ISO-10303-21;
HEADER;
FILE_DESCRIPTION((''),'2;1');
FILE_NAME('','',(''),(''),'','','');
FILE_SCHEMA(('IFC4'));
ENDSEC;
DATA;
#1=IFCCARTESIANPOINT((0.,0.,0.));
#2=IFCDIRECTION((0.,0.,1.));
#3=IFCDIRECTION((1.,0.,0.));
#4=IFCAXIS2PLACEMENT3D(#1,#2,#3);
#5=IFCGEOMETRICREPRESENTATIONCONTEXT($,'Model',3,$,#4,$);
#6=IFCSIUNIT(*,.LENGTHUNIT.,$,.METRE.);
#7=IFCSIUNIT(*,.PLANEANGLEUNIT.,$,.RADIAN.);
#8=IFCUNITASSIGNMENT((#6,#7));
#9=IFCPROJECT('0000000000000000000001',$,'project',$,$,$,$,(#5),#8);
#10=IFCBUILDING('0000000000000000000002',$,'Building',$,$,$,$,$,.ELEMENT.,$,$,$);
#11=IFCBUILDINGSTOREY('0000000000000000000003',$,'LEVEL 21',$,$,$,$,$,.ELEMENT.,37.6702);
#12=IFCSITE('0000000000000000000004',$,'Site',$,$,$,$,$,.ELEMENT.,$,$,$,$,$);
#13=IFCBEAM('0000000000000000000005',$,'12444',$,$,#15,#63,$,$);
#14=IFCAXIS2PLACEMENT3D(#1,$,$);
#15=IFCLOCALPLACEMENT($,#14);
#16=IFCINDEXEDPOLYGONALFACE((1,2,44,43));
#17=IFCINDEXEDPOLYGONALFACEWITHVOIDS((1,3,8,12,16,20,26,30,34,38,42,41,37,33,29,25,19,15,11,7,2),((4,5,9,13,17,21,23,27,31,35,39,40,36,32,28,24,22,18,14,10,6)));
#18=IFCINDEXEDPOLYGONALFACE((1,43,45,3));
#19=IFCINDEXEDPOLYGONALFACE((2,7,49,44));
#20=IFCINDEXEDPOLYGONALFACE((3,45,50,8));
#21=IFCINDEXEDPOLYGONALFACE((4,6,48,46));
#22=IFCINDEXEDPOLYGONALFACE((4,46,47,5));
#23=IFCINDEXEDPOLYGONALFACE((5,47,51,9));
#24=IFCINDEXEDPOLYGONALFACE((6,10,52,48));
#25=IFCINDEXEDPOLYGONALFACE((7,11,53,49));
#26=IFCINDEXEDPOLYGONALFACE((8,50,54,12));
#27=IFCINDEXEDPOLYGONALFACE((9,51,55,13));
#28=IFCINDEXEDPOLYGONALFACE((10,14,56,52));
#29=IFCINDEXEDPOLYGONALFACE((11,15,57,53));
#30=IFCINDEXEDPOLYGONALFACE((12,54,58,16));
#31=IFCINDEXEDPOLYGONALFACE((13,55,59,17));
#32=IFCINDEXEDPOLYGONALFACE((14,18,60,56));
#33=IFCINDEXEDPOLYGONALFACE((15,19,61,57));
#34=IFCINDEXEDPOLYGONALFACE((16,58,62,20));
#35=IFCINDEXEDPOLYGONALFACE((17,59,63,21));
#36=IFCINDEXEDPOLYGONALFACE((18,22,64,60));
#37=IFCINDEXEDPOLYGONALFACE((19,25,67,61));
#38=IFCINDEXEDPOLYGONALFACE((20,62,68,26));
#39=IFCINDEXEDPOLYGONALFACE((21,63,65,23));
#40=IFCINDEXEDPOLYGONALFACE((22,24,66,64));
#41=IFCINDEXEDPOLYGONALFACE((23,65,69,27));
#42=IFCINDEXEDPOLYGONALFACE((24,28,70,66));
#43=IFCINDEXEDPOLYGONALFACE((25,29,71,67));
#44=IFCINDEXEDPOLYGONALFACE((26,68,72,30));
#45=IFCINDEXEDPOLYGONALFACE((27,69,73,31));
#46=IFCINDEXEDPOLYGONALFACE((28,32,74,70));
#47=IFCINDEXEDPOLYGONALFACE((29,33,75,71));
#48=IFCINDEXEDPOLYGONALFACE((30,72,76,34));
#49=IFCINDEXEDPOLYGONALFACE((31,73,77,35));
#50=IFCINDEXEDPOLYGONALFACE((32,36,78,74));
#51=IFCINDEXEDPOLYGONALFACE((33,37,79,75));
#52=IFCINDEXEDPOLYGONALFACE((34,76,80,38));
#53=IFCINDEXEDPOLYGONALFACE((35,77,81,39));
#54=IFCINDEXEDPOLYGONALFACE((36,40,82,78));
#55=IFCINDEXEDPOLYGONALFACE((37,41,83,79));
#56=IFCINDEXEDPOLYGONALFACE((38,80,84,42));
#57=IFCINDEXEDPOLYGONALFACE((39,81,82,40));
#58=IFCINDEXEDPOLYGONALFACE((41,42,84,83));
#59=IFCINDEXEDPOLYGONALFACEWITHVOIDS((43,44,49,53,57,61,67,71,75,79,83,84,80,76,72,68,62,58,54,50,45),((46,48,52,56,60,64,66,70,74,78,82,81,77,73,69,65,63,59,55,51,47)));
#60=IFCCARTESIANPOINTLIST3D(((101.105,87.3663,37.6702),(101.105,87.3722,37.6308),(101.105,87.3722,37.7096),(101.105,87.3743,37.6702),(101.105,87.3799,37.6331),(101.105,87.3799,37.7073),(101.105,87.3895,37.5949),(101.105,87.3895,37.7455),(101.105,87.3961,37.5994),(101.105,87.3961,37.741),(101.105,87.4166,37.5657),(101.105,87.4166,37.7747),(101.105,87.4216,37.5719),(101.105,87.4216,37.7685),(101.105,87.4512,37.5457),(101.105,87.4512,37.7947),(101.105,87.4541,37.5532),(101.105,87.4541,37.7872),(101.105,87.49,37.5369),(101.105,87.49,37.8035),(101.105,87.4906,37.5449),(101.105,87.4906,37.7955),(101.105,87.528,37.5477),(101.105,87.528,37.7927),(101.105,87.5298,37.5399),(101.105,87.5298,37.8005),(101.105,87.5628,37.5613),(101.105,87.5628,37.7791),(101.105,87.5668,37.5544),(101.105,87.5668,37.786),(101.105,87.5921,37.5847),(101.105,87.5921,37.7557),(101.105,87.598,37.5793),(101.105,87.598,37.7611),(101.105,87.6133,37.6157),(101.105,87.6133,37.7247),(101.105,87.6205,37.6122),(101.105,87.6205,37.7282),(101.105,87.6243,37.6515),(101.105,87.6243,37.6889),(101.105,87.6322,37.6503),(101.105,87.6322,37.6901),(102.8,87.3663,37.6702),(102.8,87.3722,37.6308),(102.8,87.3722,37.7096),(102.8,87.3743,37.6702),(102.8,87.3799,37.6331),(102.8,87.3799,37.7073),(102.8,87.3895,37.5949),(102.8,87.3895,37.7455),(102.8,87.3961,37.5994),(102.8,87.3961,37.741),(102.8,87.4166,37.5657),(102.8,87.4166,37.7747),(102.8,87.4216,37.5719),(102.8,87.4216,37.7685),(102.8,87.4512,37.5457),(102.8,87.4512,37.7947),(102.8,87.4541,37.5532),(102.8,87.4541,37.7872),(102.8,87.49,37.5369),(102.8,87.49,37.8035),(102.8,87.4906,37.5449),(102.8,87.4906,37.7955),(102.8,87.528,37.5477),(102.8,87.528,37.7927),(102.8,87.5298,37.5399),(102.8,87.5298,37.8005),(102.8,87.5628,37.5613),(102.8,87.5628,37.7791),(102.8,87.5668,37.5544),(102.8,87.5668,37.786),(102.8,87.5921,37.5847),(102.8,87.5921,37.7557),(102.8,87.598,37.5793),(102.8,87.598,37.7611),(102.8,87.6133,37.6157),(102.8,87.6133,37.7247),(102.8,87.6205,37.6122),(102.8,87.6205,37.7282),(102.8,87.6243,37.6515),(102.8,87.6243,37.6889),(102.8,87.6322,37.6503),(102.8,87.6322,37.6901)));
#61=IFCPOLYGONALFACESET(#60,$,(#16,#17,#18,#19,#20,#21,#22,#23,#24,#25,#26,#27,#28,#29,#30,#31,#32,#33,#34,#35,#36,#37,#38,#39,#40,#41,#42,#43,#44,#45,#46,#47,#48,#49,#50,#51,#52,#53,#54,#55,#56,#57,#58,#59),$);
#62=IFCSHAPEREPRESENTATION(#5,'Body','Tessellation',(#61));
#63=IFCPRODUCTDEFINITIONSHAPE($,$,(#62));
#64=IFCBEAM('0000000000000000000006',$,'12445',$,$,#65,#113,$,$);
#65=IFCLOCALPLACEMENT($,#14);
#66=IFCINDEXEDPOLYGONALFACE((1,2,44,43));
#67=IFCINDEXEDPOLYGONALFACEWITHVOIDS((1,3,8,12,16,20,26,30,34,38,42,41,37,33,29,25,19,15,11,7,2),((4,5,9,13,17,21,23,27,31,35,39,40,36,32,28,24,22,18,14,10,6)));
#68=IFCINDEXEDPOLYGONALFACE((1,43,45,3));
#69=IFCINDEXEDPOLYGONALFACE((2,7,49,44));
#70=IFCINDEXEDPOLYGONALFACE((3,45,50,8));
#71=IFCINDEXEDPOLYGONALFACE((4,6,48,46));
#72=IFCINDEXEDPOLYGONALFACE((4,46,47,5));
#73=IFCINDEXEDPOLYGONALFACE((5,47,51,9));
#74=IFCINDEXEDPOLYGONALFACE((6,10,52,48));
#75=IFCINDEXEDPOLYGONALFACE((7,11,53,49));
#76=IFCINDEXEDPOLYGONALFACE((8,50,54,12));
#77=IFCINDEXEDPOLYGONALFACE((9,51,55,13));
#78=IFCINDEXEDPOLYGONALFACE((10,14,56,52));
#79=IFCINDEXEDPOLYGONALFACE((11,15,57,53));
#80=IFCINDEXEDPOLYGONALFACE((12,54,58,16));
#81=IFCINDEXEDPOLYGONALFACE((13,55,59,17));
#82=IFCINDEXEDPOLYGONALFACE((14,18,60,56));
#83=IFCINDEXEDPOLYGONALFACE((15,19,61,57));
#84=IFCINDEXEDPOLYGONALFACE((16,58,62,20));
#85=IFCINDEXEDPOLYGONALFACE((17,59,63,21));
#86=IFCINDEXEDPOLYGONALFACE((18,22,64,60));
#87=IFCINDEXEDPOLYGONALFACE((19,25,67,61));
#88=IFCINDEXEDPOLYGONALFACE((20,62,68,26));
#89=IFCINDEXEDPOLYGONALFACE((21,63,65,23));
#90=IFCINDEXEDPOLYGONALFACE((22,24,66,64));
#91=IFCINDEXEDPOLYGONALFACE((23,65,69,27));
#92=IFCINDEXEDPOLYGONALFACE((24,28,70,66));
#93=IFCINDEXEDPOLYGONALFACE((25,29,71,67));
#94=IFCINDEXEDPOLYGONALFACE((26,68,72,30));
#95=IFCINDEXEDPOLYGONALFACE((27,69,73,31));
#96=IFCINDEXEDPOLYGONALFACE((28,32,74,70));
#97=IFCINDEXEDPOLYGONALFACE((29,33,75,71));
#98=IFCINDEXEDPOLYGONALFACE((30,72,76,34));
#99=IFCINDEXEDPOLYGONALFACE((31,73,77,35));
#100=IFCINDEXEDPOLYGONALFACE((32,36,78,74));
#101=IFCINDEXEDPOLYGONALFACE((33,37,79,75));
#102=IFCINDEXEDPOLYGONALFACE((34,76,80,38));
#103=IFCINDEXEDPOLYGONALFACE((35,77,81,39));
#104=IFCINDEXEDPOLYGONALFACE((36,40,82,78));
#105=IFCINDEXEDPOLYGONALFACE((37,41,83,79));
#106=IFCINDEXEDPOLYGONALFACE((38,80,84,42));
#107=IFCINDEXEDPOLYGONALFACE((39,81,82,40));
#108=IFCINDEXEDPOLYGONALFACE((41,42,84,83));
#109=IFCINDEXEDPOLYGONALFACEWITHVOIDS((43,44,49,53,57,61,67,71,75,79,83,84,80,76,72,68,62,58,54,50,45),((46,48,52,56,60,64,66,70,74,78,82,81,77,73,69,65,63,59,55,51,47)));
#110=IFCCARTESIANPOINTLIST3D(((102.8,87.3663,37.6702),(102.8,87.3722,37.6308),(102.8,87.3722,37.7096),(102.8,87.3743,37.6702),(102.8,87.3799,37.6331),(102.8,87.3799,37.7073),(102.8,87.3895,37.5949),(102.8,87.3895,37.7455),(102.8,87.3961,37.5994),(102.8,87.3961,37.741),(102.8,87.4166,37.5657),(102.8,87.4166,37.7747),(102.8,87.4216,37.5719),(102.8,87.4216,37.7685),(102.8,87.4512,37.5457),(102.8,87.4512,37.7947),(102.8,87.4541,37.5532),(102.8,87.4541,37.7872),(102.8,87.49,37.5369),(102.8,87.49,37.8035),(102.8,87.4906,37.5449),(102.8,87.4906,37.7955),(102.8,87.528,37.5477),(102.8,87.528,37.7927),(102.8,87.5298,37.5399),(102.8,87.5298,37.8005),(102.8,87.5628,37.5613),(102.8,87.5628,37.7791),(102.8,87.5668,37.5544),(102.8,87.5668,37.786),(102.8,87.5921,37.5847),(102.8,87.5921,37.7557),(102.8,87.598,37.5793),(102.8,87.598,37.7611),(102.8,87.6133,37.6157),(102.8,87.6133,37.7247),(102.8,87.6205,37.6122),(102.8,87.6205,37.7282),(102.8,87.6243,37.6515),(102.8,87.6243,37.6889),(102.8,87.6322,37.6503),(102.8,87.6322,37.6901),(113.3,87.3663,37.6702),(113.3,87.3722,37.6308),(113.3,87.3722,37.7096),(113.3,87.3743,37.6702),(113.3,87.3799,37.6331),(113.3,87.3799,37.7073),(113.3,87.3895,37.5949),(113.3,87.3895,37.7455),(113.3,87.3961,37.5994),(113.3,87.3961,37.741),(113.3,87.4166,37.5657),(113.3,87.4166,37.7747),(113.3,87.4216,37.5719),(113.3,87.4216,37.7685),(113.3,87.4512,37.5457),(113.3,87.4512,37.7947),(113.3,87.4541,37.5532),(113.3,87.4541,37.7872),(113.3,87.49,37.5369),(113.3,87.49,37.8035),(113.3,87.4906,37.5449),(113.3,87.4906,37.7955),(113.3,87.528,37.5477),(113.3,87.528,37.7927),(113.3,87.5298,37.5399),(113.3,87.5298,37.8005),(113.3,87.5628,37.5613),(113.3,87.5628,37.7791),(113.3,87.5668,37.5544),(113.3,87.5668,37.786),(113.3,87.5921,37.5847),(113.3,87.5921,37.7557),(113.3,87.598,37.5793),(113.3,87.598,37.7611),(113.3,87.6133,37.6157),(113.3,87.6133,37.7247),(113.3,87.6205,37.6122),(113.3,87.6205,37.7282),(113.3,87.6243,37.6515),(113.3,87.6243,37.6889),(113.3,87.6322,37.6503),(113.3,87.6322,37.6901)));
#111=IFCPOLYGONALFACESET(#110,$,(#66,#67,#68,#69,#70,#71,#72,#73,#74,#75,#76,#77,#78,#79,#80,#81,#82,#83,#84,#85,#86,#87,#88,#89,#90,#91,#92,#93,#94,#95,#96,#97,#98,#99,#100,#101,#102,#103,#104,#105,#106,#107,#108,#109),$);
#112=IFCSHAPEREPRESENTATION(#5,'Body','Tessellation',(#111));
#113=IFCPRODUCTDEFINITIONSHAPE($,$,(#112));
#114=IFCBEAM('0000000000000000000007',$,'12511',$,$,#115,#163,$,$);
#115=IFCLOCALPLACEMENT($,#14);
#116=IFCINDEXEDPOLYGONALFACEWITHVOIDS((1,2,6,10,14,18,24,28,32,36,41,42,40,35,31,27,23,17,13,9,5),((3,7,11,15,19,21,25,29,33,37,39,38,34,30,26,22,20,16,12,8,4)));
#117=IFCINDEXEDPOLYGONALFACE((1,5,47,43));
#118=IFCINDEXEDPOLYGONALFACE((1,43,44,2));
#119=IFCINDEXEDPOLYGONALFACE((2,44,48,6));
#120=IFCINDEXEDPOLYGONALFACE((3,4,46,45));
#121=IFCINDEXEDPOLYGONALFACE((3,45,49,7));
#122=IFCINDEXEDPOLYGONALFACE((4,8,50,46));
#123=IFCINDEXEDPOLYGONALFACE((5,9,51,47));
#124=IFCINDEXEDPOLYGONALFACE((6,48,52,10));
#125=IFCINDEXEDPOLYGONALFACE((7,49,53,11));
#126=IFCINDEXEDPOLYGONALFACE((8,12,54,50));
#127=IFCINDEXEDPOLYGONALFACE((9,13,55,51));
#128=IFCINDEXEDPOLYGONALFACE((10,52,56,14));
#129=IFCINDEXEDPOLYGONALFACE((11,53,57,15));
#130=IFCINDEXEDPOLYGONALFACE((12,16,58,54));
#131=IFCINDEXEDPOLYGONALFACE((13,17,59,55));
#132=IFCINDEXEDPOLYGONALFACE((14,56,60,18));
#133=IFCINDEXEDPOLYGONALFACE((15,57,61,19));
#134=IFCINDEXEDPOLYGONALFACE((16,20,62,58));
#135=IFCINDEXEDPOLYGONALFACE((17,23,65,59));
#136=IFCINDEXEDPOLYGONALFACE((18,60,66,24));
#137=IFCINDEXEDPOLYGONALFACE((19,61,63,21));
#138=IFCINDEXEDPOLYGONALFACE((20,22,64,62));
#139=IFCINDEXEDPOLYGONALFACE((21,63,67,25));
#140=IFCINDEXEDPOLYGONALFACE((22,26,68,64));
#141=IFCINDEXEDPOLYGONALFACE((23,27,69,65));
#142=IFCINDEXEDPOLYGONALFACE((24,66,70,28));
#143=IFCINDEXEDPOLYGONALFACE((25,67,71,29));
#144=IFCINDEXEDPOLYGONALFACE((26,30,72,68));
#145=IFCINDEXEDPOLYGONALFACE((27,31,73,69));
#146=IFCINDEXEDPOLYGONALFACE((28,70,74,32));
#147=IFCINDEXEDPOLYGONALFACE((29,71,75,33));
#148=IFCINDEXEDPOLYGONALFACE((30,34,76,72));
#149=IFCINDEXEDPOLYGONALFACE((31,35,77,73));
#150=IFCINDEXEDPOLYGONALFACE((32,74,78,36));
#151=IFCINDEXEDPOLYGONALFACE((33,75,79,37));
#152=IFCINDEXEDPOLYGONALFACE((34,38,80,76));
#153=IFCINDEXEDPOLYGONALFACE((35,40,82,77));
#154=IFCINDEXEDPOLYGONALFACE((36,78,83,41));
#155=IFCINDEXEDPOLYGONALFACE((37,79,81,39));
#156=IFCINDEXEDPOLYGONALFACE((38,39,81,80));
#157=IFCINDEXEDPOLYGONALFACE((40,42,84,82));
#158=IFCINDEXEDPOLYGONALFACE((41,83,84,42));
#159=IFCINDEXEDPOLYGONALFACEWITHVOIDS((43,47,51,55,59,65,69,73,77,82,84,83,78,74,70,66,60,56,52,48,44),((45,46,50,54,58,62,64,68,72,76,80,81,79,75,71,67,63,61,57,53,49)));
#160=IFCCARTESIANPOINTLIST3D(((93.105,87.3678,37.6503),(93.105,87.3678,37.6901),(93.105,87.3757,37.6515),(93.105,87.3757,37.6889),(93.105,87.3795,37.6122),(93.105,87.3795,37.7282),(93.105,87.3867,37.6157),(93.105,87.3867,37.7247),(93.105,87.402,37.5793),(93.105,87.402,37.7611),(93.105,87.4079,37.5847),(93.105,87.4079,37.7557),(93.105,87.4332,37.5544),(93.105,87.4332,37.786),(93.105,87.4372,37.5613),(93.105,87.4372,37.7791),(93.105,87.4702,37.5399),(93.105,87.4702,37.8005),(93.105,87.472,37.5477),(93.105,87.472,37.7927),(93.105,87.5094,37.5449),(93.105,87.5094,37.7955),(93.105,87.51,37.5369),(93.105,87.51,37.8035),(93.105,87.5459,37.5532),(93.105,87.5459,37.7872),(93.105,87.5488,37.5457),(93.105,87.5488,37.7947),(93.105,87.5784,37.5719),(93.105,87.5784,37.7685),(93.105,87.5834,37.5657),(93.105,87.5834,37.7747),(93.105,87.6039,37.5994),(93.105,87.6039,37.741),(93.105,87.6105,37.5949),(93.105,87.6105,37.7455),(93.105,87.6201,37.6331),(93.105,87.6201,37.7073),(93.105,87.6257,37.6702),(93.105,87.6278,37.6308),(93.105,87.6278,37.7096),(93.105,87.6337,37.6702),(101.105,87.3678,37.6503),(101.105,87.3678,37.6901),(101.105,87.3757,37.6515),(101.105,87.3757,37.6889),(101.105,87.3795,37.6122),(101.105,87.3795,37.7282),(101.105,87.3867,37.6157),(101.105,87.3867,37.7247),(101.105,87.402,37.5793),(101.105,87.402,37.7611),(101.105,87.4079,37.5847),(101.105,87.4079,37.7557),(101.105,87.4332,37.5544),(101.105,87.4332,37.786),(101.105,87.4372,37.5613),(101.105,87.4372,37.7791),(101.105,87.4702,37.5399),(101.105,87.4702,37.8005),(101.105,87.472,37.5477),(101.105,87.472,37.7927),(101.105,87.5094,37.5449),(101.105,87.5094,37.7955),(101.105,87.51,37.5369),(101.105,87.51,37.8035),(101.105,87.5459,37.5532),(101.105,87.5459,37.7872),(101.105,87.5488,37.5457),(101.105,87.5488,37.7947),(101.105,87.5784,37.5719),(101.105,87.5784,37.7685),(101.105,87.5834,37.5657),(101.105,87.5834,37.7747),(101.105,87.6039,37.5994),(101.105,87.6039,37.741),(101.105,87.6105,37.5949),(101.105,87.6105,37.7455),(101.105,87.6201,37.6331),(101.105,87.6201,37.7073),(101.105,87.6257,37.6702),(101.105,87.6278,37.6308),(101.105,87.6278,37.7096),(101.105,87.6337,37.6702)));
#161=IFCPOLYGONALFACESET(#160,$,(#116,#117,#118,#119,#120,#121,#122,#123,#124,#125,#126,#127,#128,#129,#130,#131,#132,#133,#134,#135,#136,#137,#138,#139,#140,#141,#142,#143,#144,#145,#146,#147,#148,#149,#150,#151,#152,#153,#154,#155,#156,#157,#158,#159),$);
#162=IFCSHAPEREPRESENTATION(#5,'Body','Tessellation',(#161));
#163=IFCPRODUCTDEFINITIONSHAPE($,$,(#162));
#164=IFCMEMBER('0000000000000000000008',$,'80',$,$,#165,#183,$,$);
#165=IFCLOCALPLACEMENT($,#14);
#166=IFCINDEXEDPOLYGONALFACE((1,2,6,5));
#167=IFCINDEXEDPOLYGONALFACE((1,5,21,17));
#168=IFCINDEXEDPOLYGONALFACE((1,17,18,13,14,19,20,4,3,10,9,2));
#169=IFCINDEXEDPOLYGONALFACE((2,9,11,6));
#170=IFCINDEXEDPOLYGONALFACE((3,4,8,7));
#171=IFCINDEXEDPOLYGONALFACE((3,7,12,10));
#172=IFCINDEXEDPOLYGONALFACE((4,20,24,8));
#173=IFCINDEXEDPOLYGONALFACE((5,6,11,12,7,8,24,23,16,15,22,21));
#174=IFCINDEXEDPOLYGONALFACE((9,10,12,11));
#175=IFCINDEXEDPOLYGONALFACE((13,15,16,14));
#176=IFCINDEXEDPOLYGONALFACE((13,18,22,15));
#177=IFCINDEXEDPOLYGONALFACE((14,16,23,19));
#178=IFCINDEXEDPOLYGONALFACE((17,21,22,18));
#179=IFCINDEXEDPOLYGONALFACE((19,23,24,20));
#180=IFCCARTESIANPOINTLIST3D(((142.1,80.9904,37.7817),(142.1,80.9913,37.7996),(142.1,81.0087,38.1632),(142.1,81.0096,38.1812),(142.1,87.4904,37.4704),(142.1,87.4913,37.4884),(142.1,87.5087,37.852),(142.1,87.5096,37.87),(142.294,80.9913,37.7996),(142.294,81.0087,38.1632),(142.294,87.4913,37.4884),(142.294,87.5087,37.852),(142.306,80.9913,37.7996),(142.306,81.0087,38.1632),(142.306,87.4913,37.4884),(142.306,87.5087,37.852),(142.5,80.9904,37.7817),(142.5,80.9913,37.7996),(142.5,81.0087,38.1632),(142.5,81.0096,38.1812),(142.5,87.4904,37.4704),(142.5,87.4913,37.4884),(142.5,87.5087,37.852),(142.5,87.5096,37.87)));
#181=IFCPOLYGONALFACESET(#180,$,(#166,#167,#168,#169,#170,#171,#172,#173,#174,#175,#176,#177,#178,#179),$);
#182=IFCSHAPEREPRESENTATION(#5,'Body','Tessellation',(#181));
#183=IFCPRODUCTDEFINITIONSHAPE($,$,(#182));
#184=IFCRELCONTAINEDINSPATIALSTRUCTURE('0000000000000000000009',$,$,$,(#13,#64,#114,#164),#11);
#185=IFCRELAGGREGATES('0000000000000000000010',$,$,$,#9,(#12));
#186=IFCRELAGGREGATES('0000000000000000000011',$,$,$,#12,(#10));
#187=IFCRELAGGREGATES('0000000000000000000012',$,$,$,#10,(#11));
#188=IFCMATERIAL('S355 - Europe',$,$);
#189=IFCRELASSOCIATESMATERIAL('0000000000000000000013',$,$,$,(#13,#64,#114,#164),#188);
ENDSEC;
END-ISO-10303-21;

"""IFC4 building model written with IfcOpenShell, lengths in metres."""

from ifc_helpers import new_model, si_unit, frame, origin_with_axes, origin_2d_with_axis, place, context, project, spatial, hollow_circle, i_section, extrude, material, material_profile, profile_set, profile_usage, element, save


model = new_model("IFC4")

# Units and contexts
model_context = context("Model", 3, world=origin_with_axes())
ifc_project = project(units=[si_unit("LENGTHUNIT", "METRE"), si_unit("PLANEANGLEUNIT", "RADIAN")], contexts=[model_context])

# Site, building, storey
site = spatial("IfcSite", under=ifc_project, Name="Site", CompositionType="ELEMENT")
building = spatial("IfcBuilding", under=site, Name="Building", CompositionType="ELEMENT")
storey = spatial("IfcBuildingStorey", under=building, Name="LEVEL 21", CompositionType="ELEMENT", Elevation=37.6702)

# Beams
ifc_material = material(Name="S355 - Europe")
ifc_material_profile_1 = material_profile(ifc_material, hollow_circle(Radius=0.1337, WallThickness=0.008, at=origin_2d_with_axis()))
ifc_profile_set_1 = profile_set([ifc_material_profile_1])
ifc_profile_usage_1 = profile_usage(ifc_profile_set_1, cardinal=10)
beam_1_placement = place(None, frame((102.8, 87.5, 37.6702), z_axis=(-1.0, 0.0, 0.0), x_axis=(0.0, -1.0, 0.0)))
element("IfcBeam", 1, at=beam_1_placement, inside=storey, material=ifc_profile_usage_1, Name="12444", context=model_context, shape_type="SweptSolid", body=[
    extrude(hollow_circle(Radius=0.1337, WallThickness=0.008, at=origin_2d_with_axis()), origin_with_axes(), (0.0, 0.0, 1.0), 1.695),
])
ifc_material_profile_2 = material_profile(ifc_material, hollow_circle(Radius=0.1337, WallThickness=0.008, at=origin_2d_with_axis()))
ifc_profile_set_2 = profile_set([ifc_material_profile_2])
ifc_profile_usage_2 = profile_usage(ifc_profile_set_2, cardinal=10)
beam_2_placement = place(None, frame((113.3, 87.5, 37.6702), z_axis=(-1.0, 0.0, 0.0), x_axis=(0.0, -1.0, 0.0)))
element("IfcBeam", 2, at=beam_2_placement, inside=storey, material=ifc_profile_usage_2, Name="12445", context=model_context, shape_type="SweptSolid", body=[
    extrude(hollow_circle(Radius=0.1337, WallThickness=0.008, at=origin_2d_with_axis()), origin_with_axes(), (0.0, 0.0, 1.0), 10.5),
])
ifc_material_profile_3 = material_profile(ifc_material, hollow_circle(Radius=0.1337, WallThickness=0.008, at=origin_2d_with_axis()))
ifc_profile_set_3 = profile_set([ifc_material_profile_3])
ifc_profile_usage_3 = profile_usage(ifc_profile_set_3, cardinal=10)
beam_3_placement = place(None, frame((93.105, 87.5, 37.6702), z_axis=(1.0, 0.0, 0.0), x_axis=(0.0, 1.0, 0.0)))
element("IfcBeam", 3, at=beam_3_placement, inside=storey, material=ifc_profile_usage_3, Name="12511", context=model_context, shape_type="SweptSolid", body=[
    extrude(hollow_circle(Radius=0.1337, WallThickness=0.008, at=origin_2d_with_axis()), origin_with_axes(), (0.0, 0.0, 1.0), 8.0),
])

# Member
ifc_material_profile_4 = material_profile(ifc_material, i_section(OverallWidth=0.4, OverallDepth=0.4, WebThickness=0.012, FlangeThickness=0.018, at=origin_2d_with_axis()))
ifc_profile_set_4 = profile_set([ifc_material_profile_4])
ifc_profile_usage_4 = profile_usage(ifc_profile_set_4, cardinal=10)
member_1_placement = place(None, frame((142.3, 87.5, 37.6702), z_axis=(0.0, -0.998856, 0.047828), x_axis=(1.0, 0.0, 0.0)))
element("IfcMember", 4, at=member_1_placement, inside=storey, material=ifc_profile_usage_4, Name="80", context=model_context, shape_type="SweptSolid", body=[
    extrude(i_section(OverallWidth=0.4, OverallDepth=0.4, WebThickness=0.012, FlangeThickness=0.018, at=origin_2d_with_axis()), origin_with_axes(), (0.0, 0.0, 1.0), 6.5074),
])

save(model, "model.ifc")
